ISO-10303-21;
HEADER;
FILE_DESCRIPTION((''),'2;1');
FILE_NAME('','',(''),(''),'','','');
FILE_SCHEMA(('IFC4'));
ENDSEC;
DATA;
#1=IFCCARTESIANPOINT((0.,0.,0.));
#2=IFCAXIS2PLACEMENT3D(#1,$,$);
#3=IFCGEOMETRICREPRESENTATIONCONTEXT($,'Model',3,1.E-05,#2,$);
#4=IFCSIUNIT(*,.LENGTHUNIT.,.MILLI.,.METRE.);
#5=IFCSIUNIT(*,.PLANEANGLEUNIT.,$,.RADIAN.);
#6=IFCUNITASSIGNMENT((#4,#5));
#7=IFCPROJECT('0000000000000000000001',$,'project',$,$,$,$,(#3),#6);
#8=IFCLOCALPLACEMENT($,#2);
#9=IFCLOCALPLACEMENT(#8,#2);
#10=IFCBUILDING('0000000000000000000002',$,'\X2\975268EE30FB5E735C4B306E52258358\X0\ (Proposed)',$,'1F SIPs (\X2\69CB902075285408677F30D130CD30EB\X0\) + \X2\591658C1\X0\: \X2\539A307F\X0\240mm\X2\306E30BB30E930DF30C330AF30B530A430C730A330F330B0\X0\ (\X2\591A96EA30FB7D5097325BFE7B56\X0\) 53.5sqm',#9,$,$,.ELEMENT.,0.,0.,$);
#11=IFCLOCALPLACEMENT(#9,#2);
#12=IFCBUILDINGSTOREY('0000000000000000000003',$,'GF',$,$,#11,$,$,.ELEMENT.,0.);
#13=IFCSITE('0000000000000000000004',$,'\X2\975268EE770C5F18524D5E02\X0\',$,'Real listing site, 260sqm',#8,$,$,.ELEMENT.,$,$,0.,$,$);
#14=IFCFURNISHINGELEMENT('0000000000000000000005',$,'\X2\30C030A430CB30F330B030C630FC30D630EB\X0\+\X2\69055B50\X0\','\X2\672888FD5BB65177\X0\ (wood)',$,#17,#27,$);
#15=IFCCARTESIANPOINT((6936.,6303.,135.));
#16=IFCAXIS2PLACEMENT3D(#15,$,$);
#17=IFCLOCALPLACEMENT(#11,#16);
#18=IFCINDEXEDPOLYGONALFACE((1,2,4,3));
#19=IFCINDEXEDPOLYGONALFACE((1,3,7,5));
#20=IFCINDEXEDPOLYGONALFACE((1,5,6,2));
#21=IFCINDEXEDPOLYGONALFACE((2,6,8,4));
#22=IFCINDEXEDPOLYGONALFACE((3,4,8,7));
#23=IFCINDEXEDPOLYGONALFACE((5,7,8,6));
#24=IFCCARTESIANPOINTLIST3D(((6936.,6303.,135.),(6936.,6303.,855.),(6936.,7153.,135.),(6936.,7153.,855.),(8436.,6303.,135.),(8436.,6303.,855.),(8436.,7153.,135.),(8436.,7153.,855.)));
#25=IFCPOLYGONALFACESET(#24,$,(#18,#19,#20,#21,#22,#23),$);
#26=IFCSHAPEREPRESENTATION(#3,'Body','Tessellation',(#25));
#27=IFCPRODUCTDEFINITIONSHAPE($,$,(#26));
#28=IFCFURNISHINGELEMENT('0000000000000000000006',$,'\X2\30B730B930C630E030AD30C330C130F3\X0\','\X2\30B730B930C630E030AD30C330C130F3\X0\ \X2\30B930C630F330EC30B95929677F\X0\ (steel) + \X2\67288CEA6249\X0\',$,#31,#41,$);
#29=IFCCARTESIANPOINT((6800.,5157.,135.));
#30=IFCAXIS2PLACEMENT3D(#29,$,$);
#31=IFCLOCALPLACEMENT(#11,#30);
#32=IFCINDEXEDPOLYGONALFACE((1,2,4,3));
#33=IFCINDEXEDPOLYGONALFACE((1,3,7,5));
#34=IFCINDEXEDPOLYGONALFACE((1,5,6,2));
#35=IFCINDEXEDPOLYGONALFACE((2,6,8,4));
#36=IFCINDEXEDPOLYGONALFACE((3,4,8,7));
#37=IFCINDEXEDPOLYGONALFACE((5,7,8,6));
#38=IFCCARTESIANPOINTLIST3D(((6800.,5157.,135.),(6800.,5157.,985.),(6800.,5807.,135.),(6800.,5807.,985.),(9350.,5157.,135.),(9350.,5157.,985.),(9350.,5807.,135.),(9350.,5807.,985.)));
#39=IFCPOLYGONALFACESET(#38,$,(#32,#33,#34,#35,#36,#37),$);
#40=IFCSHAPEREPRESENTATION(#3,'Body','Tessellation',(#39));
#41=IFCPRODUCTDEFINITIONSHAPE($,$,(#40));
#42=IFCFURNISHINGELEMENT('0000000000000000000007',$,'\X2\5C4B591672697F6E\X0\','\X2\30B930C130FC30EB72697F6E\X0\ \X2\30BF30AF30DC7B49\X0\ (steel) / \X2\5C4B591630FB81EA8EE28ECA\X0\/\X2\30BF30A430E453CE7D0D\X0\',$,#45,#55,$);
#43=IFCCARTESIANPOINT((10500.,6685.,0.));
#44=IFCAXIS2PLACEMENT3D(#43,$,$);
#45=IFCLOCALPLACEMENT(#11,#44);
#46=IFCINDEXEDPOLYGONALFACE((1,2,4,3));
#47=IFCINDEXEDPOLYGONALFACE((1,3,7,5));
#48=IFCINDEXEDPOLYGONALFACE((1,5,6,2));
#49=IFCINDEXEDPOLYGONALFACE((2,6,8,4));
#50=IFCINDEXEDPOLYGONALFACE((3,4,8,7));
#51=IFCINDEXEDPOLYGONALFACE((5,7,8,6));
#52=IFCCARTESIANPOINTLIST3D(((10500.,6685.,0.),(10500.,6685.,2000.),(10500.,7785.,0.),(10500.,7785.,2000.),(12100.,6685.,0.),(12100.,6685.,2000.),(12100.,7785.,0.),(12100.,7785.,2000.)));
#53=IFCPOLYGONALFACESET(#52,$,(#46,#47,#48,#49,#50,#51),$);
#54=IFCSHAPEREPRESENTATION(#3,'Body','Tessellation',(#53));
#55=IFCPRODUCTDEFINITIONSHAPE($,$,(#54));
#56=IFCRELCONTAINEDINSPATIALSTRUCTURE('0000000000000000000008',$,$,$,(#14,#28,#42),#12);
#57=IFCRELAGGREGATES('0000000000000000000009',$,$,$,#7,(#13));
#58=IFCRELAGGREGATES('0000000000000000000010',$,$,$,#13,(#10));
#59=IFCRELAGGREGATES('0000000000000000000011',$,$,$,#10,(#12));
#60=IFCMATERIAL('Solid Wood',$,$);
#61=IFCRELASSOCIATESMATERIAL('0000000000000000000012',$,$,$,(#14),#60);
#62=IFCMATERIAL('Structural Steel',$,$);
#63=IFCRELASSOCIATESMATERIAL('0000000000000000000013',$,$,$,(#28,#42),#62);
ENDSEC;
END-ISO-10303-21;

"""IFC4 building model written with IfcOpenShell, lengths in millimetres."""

from ifc_helpers import new_model, si_unit, frame, frame_2d, origin, place, context, project, spatial, rectangle, extrude, material, element, save


model = new_model("IFC4")

# Units and contexts
model_context = context("Model", 3, precision=1e-05, world=origin())
ifc_project = project(units=[si_unit("LENGTHUNIT", "METRE", prefix="MILLI"), si_unit("PLANEANGLEUNIT", "RADIAN")], contexts=[model_context])

# Site, building, storey
site_placement = place(None, origin())
site = spatial("IfcSite", under=ifc_project, at=site_placement, Name="青森県弘前市", ObjectType="Real listing site, 260sqm", CompositionType="ELEMENT", RefElevation=0.0)
building_placement = place(site_placement, origin())
building = spatial("IfcBuilding", under=site, at=building_placement, Name="青森・平屋の別荘 (Proposed)", ObjectType="1F SIPs (構造用合板パネル) + 外壁: 厚み240mmのセラミックサイディング (多雪・結露対策) 53.5sqm", CompositionType="ELEMENT", ElevationOfRefHeight=0.0, ElevationOfTerrain=0.0)
storey_placement = place(building_placement, origin())
storey = spatial("IfcBuildingStorey", under=building, at=storey_placement, Name="GF", CompositionType="ELEMENT", Elevation=0.0)

# Shared definitions
ifc_material_1 = material(Name="Solid Wood")

# Shared definitions
ifc_material_2 = material(Name="Structural Steel")

# Furnishing elements
furnishing_1_placement = place(storey_placement, frame((6936.0, 6303.0, 135.0)))
element("IfcFurnishingElement", 1, at=furnishing_1_placement, inside=storey, material=ifc_material_1, Name="ダイニングテーブル+椅子", Description="木製家具 (wood)", context=model_context, shape_type="SweptSolid", body=[
    extrude(rectangle(XDim=1500.0, YDim=850.0, at=frame_2d((750.0, 425.0))), frame((6936.0, 6303.0, 135.0)), (0.0, 0.0, 1.0), 720.0),
])
furnishing_2_placement = place(storey_placement, frame((6800.0, 5157.0, 135.0)))
element("IfcFurnishingElement", 2, at=furnishing_2_placement, inside=storey, material=ifc_material_2, Name="システムキッチン", Description="システムキッチン ステンレス天板 (steel) + 木質扉", context=model_context, shape_type="SweptSolid", body=[
    extrude(rectangle(XDim=2550.0, YDim=650.0, at=frame_2d((1275.0, 325.0))), frame((6800.0, 5157.0, 135.0)), (0.0, 0.0, 1.0), 850.0),
])
furnishing_3_placement = place(storey_placement, frame((10500.0, 6685.0, 0.0)))
element("IfcFurnishingElement", 3, at=furnishing_3_placement, inside=storey, material=ifc_material_2, Name="屋外物置", Description="スチール物置 タクボ等 (steel) / 屋外・自転車/タイヤ収納", context=model_context, shape_type="SweptSolid", body=[
    extrude(rectangle(XDim=1600.0, YDim=1100.0, at=frame_2d((800.0, 550.0))), frame((10500.0, 6685.0, 0.0)), (0.0, 0.0, 1.0), 2000.0),
])

save(model, "model.ifc")
